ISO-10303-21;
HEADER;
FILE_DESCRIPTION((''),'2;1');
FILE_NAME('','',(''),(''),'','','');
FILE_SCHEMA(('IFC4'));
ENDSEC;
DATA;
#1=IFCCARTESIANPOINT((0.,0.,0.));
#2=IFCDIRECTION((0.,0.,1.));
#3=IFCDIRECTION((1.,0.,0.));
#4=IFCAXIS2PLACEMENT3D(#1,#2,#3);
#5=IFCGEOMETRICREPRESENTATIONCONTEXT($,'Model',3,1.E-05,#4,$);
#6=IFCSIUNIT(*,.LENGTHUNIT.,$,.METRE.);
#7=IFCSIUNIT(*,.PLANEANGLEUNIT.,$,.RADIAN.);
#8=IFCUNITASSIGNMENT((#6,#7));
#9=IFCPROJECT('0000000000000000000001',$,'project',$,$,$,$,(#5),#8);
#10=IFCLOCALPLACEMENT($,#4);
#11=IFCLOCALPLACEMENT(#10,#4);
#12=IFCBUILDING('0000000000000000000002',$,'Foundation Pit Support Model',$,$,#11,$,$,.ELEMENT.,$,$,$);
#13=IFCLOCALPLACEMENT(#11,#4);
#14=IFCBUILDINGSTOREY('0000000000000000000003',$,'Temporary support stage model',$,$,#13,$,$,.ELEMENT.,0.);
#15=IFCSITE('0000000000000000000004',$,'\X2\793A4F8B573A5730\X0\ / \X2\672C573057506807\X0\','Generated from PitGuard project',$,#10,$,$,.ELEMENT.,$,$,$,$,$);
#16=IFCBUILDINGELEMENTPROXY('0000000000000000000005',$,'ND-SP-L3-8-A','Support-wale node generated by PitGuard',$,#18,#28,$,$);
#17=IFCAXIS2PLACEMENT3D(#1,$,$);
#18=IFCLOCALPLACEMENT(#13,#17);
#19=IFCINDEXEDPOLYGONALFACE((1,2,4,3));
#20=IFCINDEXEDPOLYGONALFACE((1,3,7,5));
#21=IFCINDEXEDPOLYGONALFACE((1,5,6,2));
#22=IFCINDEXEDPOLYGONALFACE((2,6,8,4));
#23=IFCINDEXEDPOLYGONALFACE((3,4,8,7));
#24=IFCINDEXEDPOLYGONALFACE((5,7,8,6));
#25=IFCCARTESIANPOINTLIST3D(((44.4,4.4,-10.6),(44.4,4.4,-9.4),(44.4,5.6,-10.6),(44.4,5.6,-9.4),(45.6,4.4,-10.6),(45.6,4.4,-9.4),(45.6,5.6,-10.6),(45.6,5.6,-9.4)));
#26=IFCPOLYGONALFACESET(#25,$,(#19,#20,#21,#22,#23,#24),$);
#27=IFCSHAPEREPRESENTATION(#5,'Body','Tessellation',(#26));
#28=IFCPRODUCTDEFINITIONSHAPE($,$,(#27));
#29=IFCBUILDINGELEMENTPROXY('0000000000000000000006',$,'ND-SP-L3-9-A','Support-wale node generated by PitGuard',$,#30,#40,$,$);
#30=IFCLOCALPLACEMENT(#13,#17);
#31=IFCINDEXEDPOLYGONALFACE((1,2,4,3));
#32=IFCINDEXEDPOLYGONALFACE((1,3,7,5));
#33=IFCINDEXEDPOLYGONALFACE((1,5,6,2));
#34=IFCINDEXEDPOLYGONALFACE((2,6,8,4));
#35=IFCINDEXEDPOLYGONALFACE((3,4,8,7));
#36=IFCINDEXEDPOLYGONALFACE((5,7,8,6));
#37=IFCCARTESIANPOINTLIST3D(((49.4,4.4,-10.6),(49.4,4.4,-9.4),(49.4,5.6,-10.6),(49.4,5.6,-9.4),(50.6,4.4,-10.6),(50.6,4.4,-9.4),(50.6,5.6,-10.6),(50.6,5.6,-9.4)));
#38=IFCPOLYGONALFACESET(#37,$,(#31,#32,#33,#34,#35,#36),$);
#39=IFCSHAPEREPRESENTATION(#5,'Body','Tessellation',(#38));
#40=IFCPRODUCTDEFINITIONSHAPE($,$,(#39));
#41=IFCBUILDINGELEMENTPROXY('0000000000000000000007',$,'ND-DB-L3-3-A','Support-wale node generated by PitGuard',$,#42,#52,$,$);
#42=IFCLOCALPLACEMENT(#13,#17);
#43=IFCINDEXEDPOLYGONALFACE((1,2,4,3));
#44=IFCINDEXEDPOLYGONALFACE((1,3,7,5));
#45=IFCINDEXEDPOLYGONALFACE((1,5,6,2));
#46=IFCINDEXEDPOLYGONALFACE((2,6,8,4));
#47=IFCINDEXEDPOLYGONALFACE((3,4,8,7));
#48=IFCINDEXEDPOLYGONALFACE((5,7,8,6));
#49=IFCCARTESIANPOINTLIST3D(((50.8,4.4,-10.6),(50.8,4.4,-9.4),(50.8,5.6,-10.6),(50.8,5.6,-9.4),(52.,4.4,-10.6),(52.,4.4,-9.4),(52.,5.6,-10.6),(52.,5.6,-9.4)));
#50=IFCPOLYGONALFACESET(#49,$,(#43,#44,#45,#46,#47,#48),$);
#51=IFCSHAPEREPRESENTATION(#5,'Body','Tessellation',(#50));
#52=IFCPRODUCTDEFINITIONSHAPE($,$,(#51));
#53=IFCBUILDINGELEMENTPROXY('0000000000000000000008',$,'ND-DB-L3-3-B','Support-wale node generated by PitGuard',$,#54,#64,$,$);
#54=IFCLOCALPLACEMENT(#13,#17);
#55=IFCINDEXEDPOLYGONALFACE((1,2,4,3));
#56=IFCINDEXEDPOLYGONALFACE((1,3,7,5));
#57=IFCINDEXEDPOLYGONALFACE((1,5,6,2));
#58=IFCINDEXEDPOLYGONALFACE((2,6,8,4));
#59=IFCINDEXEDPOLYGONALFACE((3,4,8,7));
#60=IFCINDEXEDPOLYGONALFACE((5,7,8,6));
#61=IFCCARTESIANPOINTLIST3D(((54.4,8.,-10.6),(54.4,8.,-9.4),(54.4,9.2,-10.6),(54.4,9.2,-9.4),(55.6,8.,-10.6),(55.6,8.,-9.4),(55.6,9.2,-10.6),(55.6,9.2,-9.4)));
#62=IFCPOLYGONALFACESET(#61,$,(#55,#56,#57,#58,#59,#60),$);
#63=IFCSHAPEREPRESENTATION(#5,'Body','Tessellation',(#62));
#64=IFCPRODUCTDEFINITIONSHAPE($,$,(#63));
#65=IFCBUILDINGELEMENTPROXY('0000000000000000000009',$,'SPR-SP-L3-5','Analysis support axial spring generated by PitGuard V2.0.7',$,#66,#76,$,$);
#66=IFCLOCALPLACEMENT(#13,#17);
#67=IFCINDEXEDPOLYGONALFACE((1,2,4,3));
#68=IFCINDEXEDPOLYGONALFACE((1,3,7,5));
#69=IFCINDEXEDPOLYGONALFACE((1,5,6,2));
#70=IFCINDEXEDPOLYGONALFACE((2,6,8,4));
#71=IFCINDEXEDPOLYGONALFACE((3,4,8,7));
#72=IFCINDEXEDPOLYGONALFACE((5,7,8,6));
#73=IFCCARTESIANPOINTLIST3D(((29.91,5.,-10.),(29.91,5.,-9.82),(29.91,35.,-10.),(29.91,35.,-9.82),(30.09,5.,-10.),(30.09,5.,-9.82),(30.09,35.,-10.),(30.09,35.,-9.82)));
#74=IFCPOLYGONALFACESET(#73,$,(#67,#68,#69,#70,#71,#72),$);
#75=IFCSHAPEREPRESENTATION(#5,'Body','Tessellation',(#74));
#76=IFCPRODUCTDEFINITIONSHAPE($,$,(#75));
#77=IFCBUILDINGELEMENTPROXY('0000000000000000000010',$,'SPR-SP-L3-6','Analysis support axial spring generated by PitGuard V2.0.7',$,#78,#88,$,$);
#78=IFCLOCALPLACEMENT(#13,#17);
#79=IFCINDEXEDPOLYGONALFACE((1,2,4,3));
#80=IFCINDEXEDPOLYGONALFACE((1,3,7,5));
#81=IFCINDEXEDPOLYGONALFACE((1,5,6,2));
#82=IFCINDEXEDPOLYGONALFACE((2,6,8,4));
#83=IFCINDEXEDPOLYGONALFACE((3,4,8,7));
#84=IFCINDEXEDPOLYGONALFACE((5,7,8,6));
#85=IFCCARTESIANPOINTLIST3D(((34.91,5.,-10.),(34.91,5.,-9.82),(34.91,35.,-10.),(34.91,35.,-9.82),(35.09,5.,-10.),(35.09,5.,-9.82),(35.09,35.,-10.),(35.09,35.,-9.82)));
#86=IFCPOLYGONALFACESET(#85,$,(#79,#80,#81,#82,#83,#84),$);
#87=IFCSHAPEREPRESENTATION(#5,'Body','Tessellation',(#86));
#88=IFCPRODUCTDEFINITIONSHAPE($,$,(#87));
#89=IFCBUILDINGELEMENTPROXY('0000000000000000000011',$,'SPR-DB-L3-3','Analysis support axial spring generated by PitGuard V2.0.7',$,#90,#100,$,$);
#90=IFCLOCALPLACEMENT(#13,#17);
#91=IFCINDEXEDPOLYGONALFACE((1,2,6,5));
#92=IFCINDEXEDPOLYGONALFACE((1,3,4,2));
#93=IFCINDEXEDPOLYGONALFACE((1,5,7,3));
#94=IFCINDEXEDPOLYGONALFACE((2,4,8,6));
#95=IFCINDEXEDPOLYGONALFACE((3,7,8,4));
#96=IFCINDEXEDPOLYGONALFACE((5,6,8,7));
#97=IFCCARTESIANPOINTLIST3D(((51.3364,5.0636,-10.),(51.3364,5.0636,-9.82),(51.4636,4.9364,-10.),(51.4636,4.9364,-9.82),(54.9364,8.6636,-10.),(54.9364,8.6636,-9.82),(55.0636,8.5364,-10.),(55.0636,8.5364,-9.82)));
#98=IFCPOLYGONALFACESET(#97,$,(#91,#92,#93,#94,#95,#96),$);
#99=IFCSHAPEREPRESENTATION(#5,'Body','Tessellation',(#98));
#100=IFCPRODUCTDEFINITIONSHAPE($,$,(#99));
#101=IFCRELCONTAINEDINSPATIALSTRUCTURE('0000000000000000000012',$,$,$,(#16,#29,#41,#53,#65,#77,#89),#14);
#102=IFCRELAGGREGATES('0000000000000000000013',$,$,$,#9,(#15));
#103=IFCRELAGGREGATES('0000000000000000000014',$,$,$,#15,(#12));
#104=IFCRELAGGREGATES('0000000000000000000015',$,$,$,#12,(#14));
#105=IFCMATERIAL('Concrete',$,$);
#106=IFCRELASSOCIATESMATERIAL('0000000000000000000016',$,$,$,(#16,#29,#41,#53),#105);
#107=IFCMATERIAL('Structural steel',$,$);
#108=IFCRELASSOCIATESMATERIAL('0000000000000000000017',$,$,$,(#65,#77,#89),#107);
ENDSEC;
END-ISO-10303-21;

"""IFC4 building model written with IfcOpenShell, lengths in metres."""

from ifc_helpers import new_model, si_unit, frame, origin_with_axes, origin_2d, place, context, project, spatial, rectangle, extrude, material, element, save


model = new_model("IFC4")

# Units and contexts
model_context = context("Model", 3, precision=1e-05, world=origin_with_axes())
ifc_project = project(units=[si_unit("LENGTHUNIT", "METRE"), si_unit("PLANEANGLEUNIT", "RADIAN")], contexts=[model_context])

# Site, building, storey
site_placement = place(None, origin_with_axes())
site = spatial("IfcSite", under=ifc_project, at=site_placement, Name="示例场地 / 本地坐标", Description="Generated from PitGuard project", CompositionType="ELEMENT")
building_placement = place(site_placement, origin_with_axes())
building = spatial("IfcBuilding", under=site, at=building_placement, Name="Foundation Pit Support Model", CompositionType="ELEMENT")
storey_placement = place(building_placement, origin_with_axes())
storey = spatial("IfcBuildingStorey", under=building, at=storey_placement, Name="Temporary support stage model", CompositionType="ELEMENT", Elevation=0.0)

# Shared definitions
ifc_material_1 = material(Name="Structural steel")

# Shared definitions
ifc_material_2 = material(Name="Concrete")

# Building element proxies
for number, where, z_axis, x_axis, name in (
    (1, (45.0, 5.0, -10.6), (0.0, 0.0, 1.0), (1.0, 0.0, 0.0), "ND-SP-L3-8-A"),
    (2, (50.0, 5.0, -10.6), (0.0, 0.0, 1.0), (1.0, 0.0, 0.0), "ND-SP-L3-9-A"),
    (3, (51.4, 5.0, -10.6), (0.0, 0.0, 1.0), (1.0, 0.0, 0.0), "ND-DB-L3-3-A"),
    (4, (55.0, 8.6, -10.6), (0.0, 0.0, 1.0), (1.0, 0.0, 0.0), "ND-DB-L3-3-B"),
):
    element("IfcBuildingElementProxy", number, at=place(storey_placement, frame(where, z_axis=z_axis, x_axis=x_axis)), inside=storey, material=ifc_material_2, Name=name, Description="Support-wale node generated by PitGuard", context=model_context, shape_type="SweptSolid", body=[
        extrude(rectangle(XDim=1.2, YDim=1.2, at=origin_2d()), origin_with_axes(), (0.0, 0.0, 1.0), 1.2),
    ])
for number, where, z_axis, x_axis, name in (
    (5, (30.0, 20.0, -10.0), (0.0, 0.0, 1.0), (0.0, 1.0, 0.0), "SPR-SP-L3-5"),
    (6, (35.0, 20.0, -10.0), (0.0, 0.0, 1.0), (0.0, 1.0, 0.0), "SPR-SP-L3-6"),
):
    element("IfcBuildingElementProxy", number, at=place(storey_placement, frame(where, z_axis=z_axis, x_axis=x_axis)), inside=storey, material=ifc_material_1, Name=name, Description="Analysis support axial spring generated by PitGuard V2.0.7", context=model_context, shape_type="SweptSolid", body=[
        extrude(rectangle(XDim=30.0, YDim=0.18, at=origin_2d()), origin_with_axes(), (0.0, 0.0, 1.0), 0.18),
    ])
proxy_placement = place(storey_placement, frame((53.2, 6.8, -10.0), z_axis=(0.0, 0.0, 1.0), x_axis=(0.707107, 0.707107, 0.0)))
element("IfcBuildingElementProxy", 7, at=proxy_placement, inside=storey, material=ifc_material_1, Name="SPR-DB-L3-3", Description="Analysis support axial spring generated by PitGuard V2.0.7", context=model_context, shape_type="SweptSolid", body=[
    extrude(rectangle(XDim=5.0912, YDim=0.18, at=origin_2d()), origin_with_axes(), (0.0, 0.0, 1.0), 0.18),
])

save(model, "model.ifc")
